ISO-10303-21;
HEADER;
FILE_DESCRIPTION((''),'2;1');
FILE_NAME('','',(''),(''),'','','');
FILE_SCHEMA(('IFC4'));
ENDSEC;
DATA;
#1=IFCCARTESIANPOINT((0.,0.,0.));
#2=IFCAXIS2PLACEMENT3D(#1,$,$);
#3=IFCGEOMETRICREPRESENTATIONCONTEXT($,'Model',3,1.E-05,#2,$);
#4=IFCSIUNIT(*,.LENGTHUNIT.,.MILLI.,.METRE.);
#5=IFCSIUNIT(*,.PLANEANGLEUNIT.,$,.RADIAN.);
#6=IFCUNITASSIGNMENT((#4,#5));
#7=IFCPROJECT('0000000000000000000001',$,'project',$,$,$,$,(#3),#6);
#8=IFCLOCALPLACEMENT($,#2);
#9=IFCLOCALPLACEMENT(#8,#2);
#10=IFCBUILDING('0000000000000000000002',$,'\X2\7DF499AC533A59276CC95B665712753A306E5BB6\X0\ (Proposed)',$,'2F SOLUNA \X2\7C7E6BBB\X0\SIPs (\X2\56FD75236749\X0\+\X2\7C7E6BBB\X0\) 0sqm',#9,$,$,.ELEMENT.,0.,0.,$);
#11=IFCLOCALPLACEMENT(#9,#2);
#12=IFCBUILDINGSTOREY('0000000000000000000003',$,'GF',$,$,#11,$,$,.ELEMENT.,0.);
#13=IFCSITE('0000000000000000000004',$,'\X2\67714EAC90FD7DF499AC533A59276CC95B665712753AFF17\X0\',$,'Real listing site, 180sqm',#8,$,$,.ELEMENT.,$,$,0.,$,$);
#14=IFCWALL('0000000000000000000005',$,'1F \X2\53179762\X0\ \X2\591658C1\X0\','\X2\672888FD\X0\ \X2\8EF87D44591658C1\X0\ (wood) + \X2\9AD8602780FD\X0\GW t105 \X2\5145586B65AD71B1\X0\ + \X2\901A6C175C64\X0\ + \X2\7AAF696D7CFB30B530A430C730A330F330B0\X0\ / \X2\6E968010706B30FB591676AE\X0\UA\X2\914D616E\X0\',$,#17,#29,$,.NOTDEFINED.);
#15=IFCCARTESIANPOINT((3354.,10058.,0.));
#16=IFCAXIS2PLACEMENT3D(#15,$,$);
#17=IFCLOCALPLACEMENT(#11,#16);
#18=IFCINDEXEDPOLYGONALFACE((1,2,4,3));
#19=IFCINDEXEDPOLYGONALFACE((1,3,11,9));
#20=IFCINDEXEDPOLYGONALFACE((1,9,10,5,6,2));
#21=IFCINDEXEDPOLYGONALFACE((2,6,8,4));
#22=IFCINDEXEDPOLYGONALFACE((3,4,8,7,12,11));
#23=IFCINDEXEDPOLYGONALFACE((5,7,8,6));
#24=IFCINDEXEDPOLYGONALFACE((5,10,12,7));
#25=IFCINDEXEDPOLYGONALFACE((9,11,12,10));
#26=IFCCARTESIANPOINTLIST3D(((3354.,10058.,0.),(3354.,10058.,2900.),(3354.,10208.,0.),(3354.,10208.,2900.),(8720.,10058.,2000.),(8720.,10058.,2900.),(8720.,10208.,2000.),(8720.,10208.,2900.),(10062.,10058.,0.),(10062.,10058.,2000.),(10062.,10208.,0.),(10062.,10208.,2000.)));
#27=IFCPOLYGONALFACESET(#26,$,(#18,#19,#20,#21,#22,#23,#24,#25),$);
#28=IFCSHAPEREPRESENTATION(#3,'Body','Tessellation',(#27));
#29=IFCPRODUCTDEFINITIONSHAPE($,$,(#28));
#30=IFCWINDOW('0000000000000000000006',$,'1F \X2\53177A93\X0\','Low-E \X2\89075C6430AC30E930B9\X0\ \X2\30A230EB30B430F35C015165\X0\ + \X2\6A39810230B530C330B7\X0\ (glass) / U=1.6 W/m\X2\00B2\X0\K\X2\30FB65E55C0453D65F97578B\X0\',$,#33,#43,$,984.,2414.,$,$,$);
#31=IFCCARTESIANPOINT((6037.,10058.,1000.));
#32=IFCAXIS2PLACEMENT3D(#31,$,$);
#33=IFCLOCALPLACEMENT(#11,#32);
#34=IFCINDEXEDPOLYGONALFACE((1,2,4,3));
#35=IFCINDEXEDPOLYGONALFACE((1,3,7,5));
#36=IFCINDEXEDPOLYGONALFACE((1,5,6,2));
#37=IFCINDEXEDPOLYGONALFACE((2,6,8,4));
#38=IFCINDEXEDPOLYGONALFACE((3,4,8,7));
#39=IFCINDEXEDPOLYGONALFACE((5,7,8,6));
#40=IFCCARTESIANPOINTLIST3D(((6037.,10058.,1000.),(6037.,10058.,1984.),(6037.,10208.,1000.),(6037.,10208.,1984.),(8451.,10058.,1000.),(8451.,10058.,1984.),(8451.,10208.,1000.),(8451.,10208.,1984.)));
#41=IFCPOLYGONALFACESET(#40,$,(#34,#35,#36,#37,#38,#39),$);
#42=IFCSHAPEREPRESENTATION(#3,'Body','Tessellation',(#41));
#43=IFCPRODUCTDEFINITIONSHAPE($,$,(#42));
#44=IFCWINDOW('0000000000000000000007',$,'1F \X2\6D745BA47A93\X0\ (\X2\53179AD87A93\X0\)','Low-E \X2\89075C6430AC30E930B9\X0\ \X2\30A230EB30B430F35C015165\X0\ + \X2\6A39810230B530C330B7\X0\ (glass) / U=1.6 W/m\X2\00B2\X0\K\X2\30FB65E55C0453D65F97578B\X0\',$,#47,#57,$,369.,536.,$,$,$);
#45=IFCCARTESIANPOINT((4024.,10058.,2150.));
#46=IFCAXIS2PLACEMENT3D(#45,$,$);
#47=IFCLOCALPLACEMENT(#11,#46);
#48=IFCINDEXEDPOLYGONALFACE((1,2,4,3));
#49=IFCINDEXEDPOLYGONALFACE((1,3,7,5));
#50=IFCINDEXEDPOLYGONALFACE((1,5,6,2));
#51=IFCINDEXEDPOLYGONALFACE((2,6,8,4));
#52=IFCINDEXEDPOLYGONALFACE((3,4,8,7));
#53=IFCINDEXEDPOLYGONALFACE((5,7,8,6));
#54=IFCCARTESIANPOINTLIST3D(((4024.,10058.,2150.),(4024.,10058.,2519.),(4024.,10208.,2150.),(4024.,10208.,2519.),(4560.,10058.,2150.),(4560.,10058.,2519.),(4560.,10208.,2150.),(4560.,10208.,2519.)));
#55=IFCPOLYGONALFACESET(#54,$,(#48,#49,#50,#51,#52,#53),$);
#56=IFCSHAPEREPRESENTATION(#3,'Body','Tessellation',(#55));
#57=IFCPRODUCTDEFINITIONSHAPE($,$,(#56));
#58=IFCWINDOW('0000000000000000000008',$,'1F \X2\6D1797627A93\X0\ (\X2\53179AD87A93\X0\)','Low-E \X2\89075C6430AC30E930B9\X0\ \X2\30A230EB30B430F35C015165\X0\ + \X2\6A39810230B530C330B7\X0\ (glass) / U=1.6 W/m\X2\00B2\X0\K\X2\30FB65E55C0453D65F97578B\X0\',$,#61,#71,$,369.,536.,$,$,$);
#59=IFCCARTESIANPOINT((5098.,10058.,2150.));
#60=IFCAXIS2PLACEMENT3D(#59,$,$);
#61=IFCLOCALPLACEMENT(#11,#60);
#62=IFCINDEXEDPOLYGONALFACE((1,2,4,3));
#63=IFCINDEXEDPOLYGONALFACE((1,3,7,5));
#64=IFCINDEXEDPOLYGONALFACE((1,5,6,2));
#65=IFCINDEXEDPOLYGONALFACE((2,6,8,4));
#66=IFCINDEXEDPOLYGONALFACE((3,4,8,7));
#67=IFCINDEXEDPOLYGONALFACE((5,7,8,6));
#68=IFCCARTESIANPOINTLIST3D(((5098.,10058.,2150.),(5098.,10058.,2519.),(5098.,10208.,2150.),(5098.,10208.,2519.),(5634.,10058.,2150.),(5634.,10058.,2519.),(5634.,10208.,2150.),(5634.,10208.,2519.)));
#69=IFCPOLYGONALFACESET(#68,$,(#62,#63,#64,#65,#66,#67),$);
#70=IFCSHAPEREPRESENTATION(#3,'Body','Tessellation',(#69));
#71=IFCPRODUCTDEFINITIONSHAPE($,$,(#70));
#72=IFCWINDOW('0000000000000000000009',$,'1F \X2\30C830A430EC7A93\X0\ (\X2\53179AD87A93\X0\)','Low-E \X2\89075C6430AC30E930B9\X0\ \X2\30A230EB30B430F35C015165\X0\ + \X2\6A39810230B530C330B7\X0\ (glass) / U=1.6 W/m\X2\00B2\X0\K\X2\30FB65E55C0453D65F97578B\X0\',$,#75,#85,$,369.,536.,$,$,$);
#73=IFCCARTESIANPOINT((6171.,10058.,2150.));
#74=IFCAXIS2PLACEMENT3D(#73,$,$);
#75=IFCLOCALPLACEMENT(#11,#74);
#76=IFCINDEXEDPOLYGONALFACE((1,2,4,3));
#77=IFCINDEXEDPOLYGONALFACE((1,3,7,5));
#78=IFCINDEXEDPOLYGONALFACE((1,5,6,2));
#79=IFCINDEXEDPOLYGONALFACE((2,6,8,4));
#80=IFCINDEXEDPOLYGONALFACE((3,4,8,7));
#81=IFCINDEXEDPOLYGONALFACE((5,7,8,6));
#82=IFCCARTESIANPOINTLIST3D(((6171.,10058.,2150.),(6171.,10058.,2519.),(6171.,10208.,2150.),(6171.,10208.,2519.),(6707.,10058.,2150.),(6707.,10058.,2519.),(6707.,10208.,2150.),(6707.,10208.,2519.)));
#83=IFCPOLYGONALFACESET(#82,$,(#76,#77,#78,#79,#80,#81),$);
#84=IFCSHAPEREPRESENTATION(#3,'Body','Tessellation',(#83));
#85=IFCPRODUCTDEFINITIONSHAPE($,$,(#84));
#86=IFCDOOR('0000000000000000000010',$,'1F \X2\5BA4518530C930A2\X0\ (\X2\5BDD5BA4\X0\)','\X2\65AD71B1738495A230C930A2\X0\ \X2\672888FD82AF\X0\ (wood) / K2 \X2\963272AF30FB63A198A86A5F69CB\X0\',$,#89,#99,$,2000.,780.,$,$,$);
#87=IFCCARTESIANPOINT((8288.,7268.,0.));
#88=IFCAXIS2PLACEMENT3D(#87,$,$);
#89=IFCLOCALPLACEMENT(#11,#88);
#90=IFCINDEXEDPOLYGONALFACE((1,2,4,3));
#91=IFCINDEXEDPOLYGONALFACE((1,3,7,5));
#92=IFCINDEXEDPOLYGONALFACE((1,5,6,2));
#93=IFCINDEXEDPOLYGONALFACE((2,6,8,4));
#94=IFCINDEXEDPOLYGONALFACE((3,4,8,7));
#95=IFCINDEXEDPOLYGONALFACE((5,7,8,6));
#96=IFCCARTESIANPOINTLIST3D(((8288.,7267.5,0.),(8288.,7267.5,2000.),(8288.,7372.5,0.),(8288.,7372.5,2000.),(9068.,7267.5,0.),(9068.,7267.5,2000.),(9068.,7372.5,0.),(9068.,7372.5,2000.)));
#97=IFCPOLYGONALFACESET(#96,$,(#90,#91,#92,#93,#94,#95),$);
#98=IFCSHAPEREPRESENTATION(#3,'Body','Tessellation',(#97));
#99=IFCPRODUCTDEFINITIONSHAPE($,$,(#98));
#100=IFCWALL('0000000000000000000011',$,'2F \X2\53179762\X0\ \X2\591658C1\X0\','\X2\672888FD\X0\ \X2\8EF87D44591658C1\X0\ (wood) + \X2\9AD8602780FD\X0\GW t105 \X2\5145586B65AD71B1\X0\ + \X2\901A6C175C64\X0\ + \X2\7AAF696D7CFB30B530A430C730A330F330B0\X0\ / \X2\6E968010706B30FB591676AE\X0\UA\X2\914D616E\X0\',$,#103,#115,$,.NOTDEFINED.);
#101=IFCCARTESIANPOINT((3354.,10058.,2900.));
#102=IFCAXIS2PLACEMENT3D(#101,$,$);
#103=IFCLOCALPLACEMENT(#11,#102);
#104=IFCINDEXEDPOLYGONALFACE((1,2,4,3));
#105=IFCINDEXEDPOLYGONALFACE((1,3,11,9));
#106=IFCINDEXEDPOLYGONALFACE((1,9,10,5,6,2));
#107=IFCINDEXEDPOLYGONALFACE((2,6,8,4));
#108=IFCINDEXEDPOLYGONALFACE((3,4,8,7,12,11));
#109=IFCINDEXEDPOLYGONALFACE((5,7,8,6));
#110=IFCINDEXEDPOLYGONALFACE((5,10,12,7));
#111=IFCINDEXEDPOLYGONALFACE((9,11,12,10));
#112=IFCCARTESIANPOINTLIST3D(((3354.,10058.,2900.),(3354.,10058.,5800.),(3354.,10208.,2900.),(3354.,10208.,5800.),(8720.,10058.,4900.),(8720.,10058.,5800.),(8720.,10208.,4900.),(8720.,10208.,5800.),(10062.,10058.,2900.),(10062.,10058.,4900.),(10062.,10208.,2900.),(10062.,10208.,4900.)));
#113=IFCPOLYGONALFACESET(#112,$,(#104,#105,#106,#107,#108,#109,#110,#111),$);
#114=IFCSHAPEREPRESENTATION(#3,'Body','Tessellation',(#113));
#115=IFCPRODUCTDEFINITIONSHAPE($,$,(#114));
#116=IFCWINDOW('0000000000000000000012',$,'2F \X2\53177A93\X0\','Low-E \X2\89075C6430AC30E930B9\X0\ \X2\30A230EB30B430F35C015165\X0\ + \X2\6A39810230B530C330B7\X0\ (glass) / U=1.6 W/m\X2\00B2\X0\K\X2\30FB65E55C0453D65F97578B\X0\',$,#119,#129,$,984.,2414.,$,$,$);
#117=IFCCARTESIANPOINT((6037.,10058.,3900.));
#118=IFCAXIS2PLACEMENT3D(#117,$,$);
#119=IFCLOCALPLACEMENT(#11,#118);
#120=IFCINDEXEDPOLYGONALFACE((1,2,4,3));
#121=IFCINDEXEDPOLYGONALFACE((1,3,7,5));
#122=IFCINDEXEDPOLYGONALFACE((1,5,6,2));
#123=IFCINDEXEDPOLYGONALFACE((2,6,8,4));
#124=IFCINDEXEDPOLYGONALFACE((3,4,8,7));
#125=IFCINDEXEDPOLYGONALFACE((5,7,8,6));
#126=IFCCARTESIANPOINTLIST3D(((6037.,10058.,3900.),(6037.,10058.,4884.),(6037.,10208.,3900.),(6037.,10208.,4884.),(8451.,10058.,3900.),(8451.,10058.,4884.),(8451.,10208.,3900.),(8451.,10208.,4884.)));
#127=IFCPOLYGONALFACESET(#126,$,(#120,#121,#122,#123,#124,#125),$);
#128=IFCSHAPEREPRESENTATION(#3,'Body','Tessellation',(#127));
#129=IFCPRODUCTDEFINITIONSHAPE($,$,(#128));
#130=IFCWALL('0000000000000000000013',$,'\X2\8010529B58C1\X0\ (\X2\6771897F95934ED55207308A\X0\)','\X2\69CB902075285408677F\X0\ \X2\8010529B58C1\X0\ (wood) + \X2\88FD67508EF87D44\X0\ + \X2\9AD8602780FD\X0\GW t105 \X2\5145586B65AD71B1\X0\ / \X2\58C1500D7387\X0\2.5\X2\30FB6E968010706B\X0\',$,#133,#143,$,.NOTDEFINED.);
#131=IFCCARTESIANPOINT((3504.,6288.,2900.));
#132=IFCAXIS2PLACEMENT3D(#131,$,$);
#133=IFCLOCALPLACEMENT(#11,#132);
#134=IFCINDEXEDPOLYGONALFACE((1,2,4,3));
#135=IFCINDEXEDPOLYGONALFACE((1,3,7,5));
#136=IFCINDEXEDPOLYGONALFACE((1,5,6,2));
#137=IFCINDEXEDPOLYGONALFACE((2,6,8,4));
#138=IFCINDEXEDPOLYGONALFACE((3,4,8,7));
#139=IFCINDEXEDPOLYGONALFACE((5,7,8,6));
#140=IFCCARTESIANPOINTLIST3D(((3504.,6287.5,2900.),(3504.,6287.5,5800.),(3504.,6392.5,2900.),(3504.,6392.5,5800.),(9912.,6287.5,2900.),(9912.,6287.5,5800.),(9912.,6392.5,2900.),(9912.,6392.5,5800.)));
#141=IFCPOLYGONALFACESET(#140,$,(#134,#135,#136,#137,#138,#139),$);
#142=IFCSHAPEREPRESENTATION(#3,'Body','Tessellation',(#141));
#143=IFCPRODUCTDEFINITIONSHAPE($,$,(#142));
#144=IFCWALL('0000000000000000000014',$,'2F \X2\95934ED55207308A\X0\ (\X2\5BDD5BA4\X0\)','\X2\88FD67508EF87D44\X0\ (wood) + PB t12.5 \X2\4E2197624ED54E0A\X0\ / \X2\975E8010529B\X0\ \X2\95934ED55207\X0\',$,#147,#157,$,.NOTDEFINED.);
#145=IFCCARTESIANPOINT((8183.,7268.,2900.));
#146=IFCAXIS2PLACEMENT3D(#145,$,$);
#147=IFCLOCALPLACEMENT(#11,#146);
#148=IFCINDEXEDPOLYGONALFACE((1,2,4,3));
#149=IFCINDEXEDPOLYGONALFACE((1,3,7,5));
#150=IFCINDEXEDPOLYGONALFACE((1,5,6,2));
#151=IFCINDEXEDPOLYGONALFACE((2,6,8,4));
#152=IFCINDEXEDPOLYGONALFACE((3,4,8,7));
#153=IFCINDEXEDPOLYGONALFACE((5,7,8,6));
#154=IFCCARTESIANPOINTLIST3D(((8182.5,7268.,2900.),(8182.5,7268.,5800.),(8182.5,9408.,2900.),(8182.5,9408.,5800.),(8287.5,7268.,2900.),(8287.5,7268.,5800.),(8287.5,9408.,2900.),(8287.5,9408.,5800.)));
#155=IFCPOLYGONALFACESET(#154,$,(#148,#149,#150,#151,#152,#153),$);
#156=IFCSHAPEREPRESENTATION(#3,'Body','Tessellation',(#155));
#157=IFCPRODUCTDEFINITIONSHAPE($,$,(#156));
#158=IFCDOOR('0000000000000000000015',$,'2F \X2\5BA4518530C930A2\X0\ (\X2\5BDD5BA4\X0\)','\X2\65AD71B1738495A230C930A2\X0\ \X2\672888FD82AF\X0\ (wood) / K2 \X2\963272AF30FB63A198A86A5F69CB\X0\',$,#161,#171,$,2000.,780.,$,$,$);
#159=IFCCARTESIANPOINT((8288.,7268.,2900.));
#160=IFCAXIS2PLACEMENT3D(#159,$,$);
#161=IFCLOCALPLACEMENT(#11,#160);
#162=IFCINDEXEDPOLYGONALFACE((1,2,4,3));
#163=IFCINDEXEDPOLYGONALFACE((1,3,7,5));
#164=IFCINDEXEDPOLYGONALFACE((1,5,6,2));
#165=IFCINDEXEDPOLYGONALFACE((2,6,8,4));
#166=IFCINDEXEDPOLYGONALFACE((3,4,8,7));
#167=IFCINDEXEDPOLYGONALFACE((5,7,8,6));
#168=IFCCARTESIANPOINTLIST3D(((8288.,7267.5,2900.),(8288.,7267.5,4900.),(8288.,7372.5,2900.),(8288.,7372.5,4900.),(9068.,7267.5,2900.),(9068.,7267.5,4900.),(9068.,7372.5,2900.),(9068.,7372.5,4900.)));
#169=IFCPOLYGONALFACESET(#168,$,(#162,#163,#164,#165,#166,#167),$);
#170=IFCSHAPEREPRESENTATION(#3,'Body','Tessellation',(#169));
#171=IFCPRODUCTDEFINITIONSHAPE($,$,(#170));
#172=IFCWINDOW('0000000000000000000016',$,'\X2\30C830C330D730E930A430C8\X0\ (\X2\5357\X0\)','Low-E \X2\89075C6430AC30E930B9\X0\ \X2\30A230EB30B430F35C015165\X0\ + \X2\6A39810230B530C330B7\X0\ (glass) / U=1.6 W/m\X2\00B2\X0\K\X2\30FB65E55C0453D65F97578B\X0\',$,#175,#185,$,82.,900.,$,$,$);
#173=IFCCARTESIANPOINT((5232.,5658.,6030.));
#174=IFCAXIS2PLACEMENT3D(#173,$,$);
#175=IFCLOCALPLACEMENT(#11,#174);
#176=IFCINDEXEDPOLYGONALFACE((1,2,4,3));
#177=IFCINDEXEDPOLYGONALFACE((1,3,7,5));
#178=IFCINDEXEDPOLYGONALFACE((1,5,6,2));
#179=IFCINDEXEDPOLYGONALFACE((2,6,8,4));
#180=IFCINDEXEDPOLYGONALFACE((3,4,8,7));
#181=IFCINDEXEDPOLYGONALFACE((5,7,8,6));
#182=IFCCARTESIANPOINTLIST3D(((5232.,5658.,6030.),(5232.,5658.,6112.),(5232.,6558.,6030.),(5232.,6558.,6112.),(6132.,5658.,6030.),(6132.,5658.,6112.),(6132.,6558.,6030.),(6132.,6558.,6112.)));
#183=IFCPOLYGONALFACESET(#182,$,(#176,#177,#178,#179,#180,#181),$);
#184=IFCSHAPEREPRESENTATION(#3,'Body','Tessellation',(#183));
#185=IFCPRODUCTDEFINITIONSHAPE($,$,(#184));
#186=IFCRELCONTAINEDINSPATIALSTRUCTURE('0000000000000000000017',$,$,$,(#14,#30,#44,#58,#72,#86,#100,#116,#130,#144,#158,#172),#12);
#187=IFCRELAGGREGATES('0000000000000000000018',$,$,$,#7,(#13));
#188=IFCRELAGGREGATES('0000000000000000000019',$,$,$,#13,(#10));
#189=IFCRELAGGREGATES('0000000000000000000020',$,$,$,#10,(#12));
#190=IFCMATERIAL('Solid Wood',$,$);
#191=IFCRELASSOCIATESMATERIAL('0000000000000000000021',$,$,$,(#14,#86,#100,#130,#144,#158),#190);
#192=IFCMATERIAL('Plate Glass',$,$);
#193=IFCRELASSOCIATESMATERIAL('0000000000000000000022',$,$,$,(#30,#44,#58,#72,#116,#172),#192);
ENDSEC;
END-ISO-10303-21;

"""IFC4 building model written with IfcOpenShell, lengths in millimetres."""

from ifc_helpers import new_model, si_unit, frame, frame_2d, origin, place, context, project, spatial, rectangle, extrude, material, element, fill, save


model = new_model("IFC4")

# Units and contexts
model_context = context("Model", 3, precision=1e-05, world=origin())
ifc_project = project(units=[si_unit("LENGTHUNIT", "METRE", prefix="MILLI"), si_unit("PLANEANGLEUNIT", "RADIAN")], contexts=[model_context])

# Site, building, storey
site_placement = place(None, origin())
site = spatial("IfcSite", under=ifc_project, at=site_placement, Name="東京都練馬区大泉学園町７", ObjectType="Real listing site, 180sqm", CompositionType="ELEMENT", RefElevation=0.0)
building_placement = place(site_placement, origin())
building = spatial("IfcBuilding", under=site, at=building_placement, Name="練馬区大泉学園町の家 (Proposed)", ObjectType="2F SOLUNA 籾殻SIPs (国産杉+籾殻) 0sqm", CompositionType="ELEMENT", ElevationOfRefHeight=0.0, ElevationOfTerrain=0.0)
storey_placement = place(building_placement, origin())
storey = spatial("IfcBuildingStorey", under=building, at=storey_placement, Name="GF", CompositionType="ELEMENT", Elevation=0.0)

# Wall, openings, windows
ifc_material_1 = material(Name="Solid Wood")
wall_1_placement = place(storey_placement, frame((3354.0, 10058.0, 0.0)))
wall_1 = element("IfcWall", 1, at=wall_1_placement, inside=storey, material=ifc_material_1, Name="1F 北面 外壁", Description="木製 軸組外壁 (wood) + 高性能GW t105 充填断熱 + 通気層 + 窯業系サイディング / 準耐火・外皮UA配慮", PredefinedType="NOTDEFINED", context=model_context, shape_type="SweptSolid", body=[
    extrude(rectangle(XDim=6708.0, YDim=150.0, at=frame_2d((3354.0, 75.0))), frame((3354.0, 10058.0, 0.0)), (0.0, 0.0, 1.0), 2900.0),
])
opening_1_placement = place(storey_placement, frame((6037.0, 10058.0, 1000.0)))
opening_1 = element("IfcOpeningElement", 2, at=opening_1_placement, cuts=wall_1, PredefinedType="NOTDEFINED", context=model_context, shape_type="SweptSolid", body=[
    extrude(rectangle(XDim=2414.0, YDim=150.0, at=frame_2d((1207.0, 75.0))), frame((6037.0, 10058.0, 1000.0)), (0.0, 0.0, 1.0), 984.0),
])
opening_2_placement = place(storey_placement, frame((4024.0, 10058.0, 2150.0)))
opening_2 = element("IfcOpeningElement", 3, at=opening_2_placement, cuts=wall_1, PredefinedType="NOTDEFINED", context=model_context, shape_type="SweptSolid", body=[
    extrude(rectangle(XDim=536.0, YDim=150.0, at=frame_2d((268.0, 75.0))), frame((4024.0, 10058.0, 2150.0)), (0.0, 0.0, 1.0), 369.0),
])
opening_3_placement = place(storey_placement, frame((5098.0, 10058.0, 2150.0)))
opening_3 = element("IfcOpeningElement", 4, at=opening_3_placement, cuts=wall_1, PredefinedType="NOTDEFINED", context=model_context, shape_type="SweptSolid", body=[
    extrude(rectangle(XDim=536.0, YDim=150.0, at=frame_2d((268.0, 75.0))), frame((5098.0, 10058.0, 2150.0)), (0.0, 0.0, 1.0), 369.0),
])
opening_4_placement = place(storey_placement, frame((6171.0, 10058.0, 2150.0)))
opening_4 = element("IfcOpeningElement", 5, at=opening_4_placement, cuts=wall_1, PredefinedType="NOTDEFINED", context=model_context, shape_type="SweptSolid", body=[
    extrude(rectangle(XDim=536.0, YDim=150.0, at=frame_2d((268.0, 75.0))), frame((6171.0, 10058.0, 2150.0)), (0.0, 0.0, 1.0), 369.0),
])
ifc_material_2 = material(Name="Plate Glass")
window_1_placement = place(storey_placement, frame((6037.0, 10058.0, 1000.0)))
window_1 = element("IfcWindow", 6, at=window_1_placement, inside=storey, material=ifc_material_2, Name="1F 北窓", Description="Low-E 複層ガラス アルゴン封入 + 樹脂サッシ (glass) / U=1.6 W/m²K・日射取得型", OverallHeight=984.0, OverallWidth=2414.0, context=model_context, shape_type="SweptSolid", body=[
    extrude(rectangle(XDim=2414.0, YDim=150.0, at=frame_2d((1207.0, 75.0))), frame((6037.0, 10058.0, 1000.0)), (0.0, 0.0, 1.0), 984.0),
])
fill(opening_1, window_1)
window_2_placement = place(storey_placement, frame((4024.0, 10058.0, 2150.0)))
window_2 = element("IfcWindow", 7, at=window_2_placement, inside=storey, material=ifc_material_2, Name="1F 浴室窓 (北高窓)", Description="Low-E 複層ガラス アルゴン封入 + 樹脂サッシ (glass) / U=1.6 W/m²K・日射取得型", OverallHeight=369.0, OverallWidth=536.0, context=model_context, shape_type="SweptSolid", body=[
    extrude(rectangle(XDim=536.0, YDim=150.0, at=frame_2d((268.0, 75.0))), frame((4024.0, 10058.0, 2150.0)), (0.0, 0.0, 1.0), 369.0),
])
fill(opening_2, window_2)
window_3_placement = place(storey_placement, frame((5098.0, 10058.0, 2150.0)))
window_3 = element("IfcWindow", 8, at=window_3_placement, inside=storey, material=ifc_material_2, Name="1F 洗面窓 (北高窓)", Description="Low-E 複層ガラス アルゴン封入 + 樹脂サッシ (glass) / U=1.6 W/m²K・日射取得型", OverallHeight=369.0, OverallWidth=536.0, context=model_context, shape_type="SweptSolid", body=[
    extrude(rectangle(XDim=536.0, YDim=150.0, at=frame_2d((268.0, 75.0))), frame((5098.0, 10058.0, 2150.0)), (0.0, 0.0, 1.0), 369.0),
])
fill(opening_3, window_3)
window_4_placement = place(storey_placement, frame((6171.0, 10058.0, 2150.0)))
window_4 = element("IfcWindow", 9, at=window_4_placement, inside=storey, material=ifc_material_2, Name="1F トイレ窓 (北高窓)", Description="Low-E 複層ガラス アルゴン封入 + 樹脂サッシ (glass) / U=1.6 W/m²K・日射取得型", OverallHeight=369.0, OverallWidth=536.0, context=model_context, shape_type="SweptSolid", body=[
    extrude(rectangle(XDim=536.0, YDim=150.0, at=frame_2d((268.0, 75.0))), frame((6171.0, 10058.0, 2150.0)), (0.0, 0.0, 1.0), 369.0),
])
fill(opening_4, window_4)

# Door
door_1_placement = place(storey_placement, frame((8288.0, 7268.0, 0.0)))
element("IfcDoor", 10, at=door_1_placement, inside=storey, material=ifc_material_1, Name="1F 室内ドア (寝室)", Description="断熱玄関ドア 木製芯 (wood) / K2 防犯・採風機構", OverallHeight=2000.0, OverallWidth=780.0, context=model_context, shape_type="SweptSolid", body=[
    extrude(rectangle(XDim=780.0, YDim=105.0, at=frame_2d((390.0, 52.0))), frame((8288.0, 7268.0, 0.0)), (0.0, 0.0, 1.0), 2000.0),
])

# Wall, opening, window
wall_2_placement = place(storey_placement, frame((3354.0, 10058.0, 2900.0)))
wall_2 = element("IfcWall", 11, at=wall_2_placement, inside=storey, material=ifc_material_1, Name="2F 北面 外壁", Description="木製 軸組外壁 (wood) + 高性能GW t105 充填断熱 + 通気層 + 窯業系サイディング / 準耐火・外皮UA配慮", PredefinedType="NOTDEFINED", context=model_context, shape_type="SweptSolid", body=[
    extrude(rectangle(XDim=6708.0, YDim=150.0, at=frame_2d((3354.0, 75.0))), frame((3354.0, 10058.0, 2900.0)), (0.0, 0.0, 1.0), 2900.0),
])
opening_5_placement = place(storey_placement, frame((6037.0, 10058.0, 3900.0)))
opening_5 = element("IfcOpeningElement", 12, at=opening_5_placement, cuts=wall_2, PredefinedType="NOTDEFINED", context=model_context, shape_type="SweptSolid", body=[
    extrude(rectangle(XDim=2414.0, YDim=150.0, at=frame_2d((1207.0, 75.0))), frame((6037.0, 10058.0, 3900.0)), (0.0, 0.0, 1.0), 984.0),
])
window_5_placement = place(storey_placement, frame((6037.0, 10058.0, 3900.0)))
window_5 = element("IfcWindow", 13, at=window_5_placement, inside=storey, material=ifc_material_2, Name="2F 北窓", Description="Low-E 複層ガラス アルゴン封入 + 樹脂サッシ (glass) / U=1.6 W/m²K・日射取得型", OverallHeight=984.0, OverallWidth=2414.0, context=model_context, shape_type="SweptSolid", body=[
    extrude(rectangle(XDim=2414.0, YDim=150.0, at=frame_2d((1207.0, 75.0))), frame((6037.0, 10058.0, 3900.0)), (0.0, 0.0, 1.0), 984.0),
])
fill(opening_5, window_5)

# Walls
wall_3_placement = place(storey_placement, frame((3504.0, 6288.0, 2900.0)))
element("IfcWall", 14, at=wall_3_placement, inside=storey, material=ifc_material_1, Name="耐力壁 (東西間仕切り)", Description="構造用合板 耐力壁 (wood) + 製材軸組 + 高性能GW t105 充填断熱 / 壁倍率2.5・準耐火", PredefinedType="NOTDEFINED", context=model_context, shape_type="SweptSolid", body=[
    extrude(rectangle(XDim=6408.0, YDim=105.0, at=frame_2d((3204.0, 52.0))), frame((3504.0, 6288.0, 2900.0)), (0.0, 0.0, 1.0), 2900.0),
])
wall_4_placement = place(storey_placement, frame((8183.0, 7268.0, 2900.0)))
element("IfcWall", 15, at=wall_4_placement, inside=storey, material=ifc_material_1, Name="2F 間仕切り (寝室)", Description="製材軸組 (wood) + PB t12.5 両面仕上 / 非耐力 間仕切", PredefinedType="NOTDEFINED", context=model_context, shape_type="SweptSolid", body=[
    extrude(rectangle(XDim=105.0, YDim=2140.0, at=frame_2d((52.0, 1070.0))), frame((8183.0, 7268.0, 2900.0)), (0.0, 0.0, 1.0), 2900.0),
])

# Door
door_2_placement = place(storey_placement, frame((8288.0, 7268.0, 2900.0)))
element("IfcDoor", 16, at=door_2_placement, inside=storey, material=ifc_material_1, Name="2F 室内ドア (寝室)", Description="断熱玄関ドア 木製芯 (wood) / K2 防犯・採風機構", OverallHeight=2000.0, OverallWidth=780.0, context=model_context, shape_type="SweptSolid", body=[
    extrude(rectangle(XDim=780.0, YDim=105.0, at=frame_2d((390.0, 52.0))), frame((8288.0, 7268.0, 2900.0)), (0.0, 0.0, 1.0), 2000.0),
])

# Window
window_6_placement = place(storey_placement, frame((5232.0, 5658.0, 6030.0)))
element("IfcWindow", 17, at=window_6_placement, inside=storey, material=ifc_material_2, Name="トップライト (南)", Description="Low-E 複層ガラス アルゴン封入 + 樹脂サッシ (glass) / U=1.6 W/m²K・日射取得型", OverallHeight=82.0, OverallWidth=900.0, context=model_context, shape_type="SweptSolid", body=[
    extrude(rectangle(XDim=900.0, YDim=900.0, at=frame_2d((450.0, 450.0))), frame((5232.0, 5658.0, 6030.0)), (0.0, 0.0, 1.0), 82.0),
])

save(model, "model.ifc")
